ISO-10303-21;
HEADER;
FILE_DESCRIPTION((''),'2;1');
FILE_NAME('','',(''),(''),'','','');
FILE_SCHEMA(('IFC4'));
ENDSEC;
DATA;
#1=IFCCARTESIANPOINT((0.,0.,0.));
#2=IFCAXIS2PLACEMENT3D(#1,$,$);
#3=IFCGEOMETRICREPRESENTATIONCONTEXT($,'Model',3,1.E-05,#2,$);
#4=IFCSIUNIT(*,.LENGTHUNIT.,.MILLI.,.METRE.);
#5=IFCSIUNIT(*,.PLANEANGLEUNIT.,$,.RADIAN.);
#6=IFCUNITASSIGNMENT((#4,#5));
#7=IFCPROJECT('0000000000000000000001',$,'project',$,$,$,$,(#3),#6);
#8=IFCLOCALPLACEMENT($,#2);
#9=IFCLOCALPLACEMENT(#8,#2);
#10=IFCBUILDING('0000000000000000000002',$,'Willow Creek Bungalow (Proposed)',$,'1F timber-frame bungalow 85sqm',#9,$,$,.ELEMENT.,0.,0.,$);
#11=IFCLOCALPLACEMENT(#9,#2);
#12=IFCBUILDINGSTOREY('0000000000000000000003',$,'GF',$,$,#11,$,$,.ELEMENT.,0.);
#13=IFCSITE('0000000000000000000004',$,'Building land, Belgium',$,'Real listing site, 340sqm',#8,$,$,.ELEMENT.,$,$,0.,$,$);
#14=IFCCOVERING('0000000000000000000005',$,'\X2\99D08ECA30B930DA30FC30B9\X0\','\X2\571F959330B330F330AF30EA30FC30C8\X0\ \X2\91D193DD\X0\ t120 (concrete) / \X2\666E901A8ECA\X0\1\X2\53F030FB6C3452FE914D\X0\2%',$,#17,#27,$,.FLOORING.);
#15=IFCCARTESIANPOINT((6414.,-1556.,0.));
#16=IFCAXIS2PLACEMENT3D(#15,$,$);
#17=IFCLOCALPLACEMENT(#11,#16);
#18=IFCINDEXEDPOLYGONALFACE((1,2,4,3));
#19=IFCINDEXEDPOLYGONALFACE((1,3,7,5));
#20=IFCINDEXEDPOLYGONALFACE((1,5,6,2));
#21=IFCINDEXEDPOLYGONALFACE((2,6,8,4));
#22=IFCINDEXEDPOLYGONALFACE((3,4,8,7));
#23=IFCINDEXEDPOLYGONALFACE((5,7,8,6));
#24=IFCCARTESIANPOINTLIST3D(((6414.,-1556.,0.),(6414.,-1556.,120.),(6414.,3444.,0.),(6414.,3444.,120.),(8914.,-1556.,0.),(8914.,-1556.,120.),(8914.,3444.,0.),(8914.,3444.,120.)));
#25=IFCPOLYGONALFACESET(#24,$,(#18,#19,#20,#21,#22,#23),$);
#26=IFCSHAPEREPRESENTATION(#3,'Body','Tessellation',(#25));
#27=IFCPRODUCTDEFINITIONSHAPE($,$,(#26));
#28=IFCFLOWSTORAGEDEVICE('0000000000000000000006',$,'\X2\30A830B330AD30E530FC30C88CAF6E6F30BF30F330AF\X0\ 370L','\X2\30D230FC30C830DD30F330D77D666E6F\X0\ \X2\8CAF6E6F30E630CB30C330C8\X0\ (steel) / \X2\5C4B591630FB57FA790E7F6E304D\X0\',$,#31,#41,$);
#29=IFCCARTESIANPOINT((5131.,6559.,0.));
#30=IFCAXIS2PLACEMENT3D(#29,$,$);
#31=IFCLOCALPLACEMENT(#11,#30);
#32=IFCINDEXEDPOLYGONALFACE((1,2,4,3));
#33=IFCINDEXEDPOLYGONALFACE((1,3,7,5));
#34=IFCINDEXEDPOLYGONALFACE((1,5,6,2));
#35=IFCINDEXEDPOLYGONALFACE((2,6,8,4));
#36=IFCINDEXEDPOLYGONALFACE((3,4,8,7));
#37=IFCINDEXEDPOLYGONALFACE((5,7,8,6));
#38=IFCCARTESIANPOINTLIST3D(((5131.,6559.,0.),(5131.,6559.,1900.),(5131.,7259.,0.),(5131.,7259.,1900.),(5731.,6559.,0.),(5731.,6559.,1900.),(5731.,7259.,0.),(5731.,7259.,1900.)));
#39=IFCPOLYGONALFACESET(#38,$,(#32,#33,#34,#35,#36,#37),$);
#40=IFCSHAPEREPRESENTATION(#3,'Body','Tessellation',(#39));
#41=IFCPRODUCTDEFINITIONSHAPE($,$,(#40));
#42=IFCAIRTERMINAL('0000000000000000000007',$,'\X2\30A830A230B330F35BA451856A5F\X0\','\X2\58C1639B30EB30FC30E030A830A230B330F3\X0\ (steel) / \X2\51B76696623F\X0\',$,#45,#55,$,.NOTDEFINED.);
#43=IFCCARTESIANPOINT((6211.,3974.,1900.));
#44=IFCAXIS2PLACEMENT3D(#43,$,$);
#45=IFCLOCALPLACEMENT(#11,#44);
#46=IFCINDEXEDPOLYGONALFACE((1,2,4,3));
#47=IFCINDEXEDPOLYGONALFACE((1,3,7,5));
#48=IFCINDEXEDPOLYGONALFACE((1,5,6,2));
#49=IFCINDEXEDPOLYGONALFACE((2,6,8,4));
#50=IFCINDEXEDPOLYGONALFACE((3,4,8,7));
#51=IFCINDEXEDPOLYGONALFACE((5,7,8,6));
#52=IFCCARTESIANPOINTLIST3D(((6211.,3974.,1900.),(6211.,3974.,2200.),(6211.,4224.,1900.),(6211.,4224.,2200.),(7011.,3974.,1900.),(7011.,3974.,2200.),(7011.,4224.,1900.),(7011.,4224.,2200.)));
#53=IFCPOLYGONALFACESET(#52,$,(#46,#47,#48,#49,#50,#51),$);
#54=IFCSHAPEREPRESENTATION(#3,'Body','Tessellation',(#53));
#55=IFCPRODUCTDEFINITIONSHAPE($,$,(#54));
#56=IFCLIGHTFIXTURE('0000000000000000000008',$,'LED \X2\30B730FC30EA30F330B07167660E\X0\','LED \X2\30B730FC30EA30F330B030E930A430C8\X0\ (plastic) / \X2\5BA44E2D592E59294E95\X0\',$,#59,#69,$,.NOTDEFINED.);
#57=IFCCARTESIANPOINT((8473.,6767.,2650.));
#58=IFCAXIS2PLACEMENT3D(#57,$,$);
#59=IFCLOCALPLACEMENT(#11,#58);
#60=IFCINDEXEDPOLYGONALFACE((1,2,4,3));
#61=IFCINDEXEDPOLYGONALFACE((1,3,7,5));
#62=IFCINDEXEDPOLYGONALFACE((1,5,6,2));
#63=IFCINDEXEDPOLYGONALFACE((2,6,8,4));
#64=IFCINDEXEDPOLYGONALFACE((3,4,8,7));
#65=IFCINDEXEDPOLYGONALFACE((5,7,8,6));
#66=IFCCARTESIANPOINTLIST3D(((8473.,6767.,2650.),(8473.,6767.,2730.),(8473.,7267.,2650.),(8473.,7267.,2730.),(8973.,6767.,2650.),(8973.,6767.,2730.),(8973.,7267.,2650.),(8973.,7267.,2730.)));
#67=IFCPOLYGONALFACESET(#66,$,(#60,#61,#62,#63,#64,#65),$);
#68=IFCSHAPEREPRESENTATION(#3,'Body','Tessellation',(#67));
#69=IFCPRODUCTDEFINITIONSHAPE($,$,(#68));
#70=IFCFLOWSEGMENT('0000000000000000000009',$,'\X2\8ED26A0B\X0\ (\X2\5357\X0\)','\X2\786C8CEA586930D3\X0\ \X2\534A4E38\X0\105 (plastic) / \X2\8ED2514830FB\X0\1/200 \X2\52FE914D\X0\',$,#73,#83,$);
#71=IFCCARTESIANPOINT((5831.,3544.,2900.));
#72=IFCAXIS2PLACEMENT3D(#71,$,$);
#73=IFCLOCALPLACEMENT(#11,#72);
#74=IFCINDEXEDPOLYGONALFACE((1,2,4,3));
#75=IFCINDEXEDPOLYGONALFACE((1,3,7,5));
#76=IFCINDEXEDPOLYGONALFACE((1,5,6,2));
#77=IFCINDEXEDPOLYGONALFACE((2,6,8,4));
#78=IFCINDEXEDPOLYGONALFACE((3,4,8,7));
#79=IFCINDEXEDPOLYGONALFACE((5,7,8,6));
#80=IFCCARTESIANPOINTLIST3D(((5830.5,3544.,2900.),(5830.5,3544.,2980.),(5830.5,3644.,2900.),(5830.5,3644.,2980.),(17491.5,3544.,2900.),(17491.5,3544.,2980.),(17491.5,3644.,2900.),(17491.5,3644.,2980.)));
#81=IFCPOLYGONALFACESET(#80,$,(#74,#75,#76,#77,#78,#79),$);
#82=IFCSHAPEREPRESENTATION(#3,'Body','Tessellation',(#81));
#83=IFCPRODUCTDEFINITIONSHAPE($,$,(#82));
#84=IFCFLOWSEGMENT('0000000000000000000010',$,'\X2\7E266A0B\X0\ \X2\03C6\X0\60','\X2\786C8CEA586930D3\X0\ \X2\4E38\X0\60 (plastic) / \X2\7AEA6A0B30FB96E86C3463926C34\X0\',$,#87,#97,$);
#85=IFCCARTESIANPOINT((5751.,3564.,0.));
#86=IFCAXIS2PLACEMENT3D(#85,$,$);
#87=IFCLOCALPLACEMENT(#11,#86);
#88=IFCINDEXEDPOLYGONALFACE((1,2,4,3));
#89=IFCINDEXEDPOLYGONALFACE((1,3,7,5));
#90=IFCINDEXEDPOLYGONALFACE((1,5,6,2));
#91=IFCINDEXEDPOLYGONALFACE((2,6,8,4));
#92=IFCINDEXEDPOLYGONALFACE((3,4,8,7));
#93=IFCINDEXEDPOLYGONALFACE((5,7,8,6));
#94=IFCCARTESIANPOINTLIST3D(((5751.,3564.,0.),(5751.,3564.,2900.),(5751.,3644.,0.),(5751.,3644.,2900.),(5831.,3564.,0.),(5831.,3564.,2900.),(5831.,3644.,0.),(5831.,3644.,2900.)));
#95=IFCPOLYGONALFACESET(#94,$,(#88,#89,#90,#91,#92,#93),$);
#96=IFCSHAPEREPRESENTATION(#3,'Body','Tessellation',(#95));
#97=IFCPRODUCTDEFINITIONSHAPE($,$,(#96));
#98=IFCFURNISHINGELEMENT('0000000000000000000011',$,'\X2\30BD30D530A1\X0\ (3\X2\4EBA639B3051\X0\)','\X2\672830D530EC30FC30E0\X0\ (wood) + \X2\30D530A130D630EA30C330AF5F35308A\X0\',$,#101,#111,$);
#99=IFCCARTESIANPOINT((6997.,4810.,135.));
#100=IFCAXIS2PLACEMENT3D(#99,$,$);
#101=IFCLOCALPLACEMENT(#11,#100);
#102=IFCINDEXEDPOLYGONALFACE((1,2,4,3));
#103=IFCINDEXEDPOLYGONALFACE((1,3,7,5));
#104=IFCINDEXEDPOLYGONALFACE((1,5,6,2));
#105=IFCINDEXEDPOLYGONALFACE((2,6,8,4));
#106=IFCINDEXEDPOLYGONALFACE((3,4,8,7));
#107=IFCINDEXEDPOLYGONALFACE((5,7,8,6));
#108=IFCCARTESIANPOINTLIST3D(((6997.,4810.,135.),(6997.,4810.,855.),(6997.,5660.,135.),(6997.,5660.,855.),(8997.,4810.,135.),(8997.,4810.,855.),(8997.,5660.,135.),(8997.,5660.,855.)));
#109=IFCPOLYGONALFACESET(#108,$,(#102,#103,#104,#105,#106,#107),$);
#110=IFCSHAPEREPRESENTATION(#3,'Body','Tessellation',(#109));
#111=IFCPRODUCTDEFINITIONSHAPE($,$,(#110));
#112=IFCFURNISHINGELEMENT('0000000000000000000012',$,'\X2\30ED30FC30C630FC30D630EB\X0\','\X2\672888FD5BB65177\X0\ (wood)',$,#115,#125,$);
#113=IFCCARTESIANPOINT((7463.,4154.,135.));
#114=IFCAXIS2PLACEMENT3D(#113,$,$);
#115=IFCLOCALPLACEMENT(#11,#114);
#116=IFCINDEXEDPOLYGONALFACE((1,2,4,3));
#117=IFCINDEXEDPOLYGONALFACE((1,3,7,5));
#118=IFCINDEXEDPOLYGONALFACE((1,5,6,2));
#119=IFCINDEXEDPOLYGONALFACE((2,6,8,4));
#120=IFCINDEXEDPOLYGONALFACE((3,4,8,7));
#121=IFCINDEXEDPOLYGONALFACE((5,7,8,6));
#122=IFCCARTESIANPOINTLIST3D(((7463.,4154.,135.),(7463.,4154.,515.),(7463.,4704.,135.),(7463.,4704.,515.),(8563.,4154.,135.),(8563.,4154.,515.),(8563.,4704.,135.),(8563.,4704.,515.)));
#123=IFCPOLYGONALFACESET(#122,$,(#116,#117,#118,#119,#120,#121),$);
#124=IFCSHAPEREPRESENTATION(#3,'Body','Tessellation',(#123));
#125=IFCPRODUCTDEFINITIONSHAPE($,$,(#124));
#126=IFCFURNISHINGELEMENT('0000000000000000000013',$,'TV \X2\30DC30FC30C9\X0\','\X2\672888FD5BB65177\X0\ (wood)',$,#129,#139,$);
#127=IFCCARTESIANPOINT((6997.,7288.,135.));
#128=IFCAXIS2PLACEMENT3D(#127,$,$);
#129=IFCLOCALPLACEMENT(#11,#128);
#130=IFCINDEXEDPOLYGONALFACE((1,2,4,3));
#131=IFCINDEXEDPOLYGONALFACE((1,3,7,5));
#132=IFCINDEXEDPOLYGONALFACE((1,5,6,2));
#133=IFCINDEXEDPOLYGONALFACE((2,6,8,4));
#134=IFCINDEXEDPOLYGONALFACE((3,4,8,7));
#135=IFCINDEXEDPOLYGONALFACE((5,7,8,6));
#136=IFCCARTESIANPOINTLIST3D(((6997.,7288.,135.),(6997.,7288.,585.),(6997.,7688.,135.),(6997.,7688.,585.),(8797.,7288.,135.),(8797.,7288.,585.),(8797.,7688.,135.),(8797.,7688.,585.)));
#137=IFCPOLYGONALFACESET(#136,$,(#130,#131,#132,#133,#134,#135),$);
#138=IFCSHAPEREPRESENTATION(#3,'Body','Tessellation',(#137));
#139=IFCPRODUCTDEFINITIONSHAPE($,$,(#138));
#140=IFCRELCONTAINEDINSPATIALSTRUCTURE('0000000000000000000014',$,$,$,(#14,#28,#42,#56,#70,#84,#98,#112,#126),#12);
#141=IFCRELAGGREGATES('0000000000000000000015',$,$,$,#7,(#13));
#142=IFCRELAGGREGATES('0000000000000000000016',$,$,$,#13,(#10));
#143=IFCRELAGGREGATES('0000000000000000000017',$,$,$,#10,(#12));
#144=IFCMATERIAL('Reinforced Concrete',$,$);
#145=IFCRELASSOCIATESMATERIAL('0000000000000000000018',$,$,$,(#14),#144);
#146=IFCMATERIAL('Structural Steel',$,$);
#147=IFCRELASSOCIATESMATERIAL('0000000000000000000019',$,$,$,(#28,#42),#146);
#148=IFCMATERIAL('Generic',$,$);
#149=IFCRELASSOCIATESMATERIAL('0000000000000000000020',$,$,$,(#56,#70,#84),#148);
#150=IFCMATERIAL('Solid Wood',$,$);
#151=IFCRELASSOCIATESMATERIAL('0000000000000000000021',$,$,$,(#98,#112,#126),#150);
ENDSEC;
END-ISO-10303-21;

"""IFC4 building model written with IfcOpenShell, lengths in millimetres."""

from ifc_helpers import new_model, si_unit, frame, frame_2d, origin, place, context, project, spatial, rectangle, extrude, material, element, save


model = new_model("IFC4")

# Units and contexts
model_context = context("Model", 3, precision=1e-05, world=origin())
ifc_project = project(units=[si_unit("LENGTHUNIT", "METRE", prefix="MILLI"), si_unit("PLANEANGLEUNIT", "RADIAN")], contexts=[model_context])

# Site, building, storey
site_placement = place(None, origin())
site = spatial("IfcSite", under=ifc_project, at=site_placement, Name="Building land, Belgium", ObjectType="Real listing site, 340sqm", CompositionType="ELEMENT", RefElevation=0.0)
building_placement = place(site_placement, origin())
building = spatial("IfcBuilding", under=site, at=building_placement, Name="Willow Creek Bungalow (Proposed)", ObjectType="1F timber-frame bungalow 85sqm", CompositionType="ELEMENT", ElevationOfRefHeight=0.0, ElevationOfTerrain=0.0)
storey_placement = place(building_placement, origin())
storey = spatial("IfcBuildingStorey", under=building, at=storey_placement, Name="GF", CompositionType="ELEMENT", Elevation=0.0)

# Shared definitions
ifc_material_1 = material(Name="Solid Wood")

# Shared definitions
ifc_material_2 = material(Name="Reinforced Concrete")

# Shared definitions
ifc_material_3 = material(Name="Structural Steel")

# Covering
ifc_material_4 = material(Name="Generic")
covering_1_placement = place(storey_placement, frame((6414.0, -1556.0, 0.0)))
element("IfcCovering", 1, at=covering_1_placement, inside=storey, material=ifc_material_2, Name="駐車スペース", Description="土間コンクリート 金鏝 t120 (concrete) / 普通車1台・水勾配2%", PredefinedType="FLOORING", context=model_context, shape_type="SweptSolid", body=[
    extrude(rectangle(XDim=2500.0, YDim=5000.0, at=frame_2d((1250.0, 2500.0))), frame((6414.0, -1556.0, 0.0)), (0.0, 0.0, 1.0), 120.0),
])

# Flow storage device
flow_storage_device_placement = place(storey_placement, frame((5131.0, 6559.0, 0.0)))
element("IfcFlowStorageDevice", 2, at=flow_storage_device_placement, inside=storey, material=ifc_material_3, Name="エコキュート貯湯タンク 370L", Description="ヒートポンプ給湯 貯湯ユニット (steel) / 屋外・基礎置き", context=model_context, shape_type="SweptSolid", body=[
    extrude(rectangle(XDim=600.0, YDim=700.0, at=frame_2d((300.0, 350.0))), frame((5131.0, 6559.0, 0.0)), (0.0, 0.0, 1.0), 1900.0),
])

# Air terminal
air_terminal_placement = place(storey_placement, frame((6211.0, 3974.0, 1900.0)))
element("IfcAirTerminal", 3, at=air_terminal_placement, inside=storey, material=ifc_material_3, Name="エアコン室内機", Description="壁掛ルームエアコン (steel) / 冷暖房", PredefinedType="NOTDEFINED", context=model_context, shape_type="SweptSolid", body=[
    extrude(rectangle(XDim=800.0, YDim=250.0, at=frame_2d((400.0, 125.0))), frame((6211.0, 3974.0, 1900.0)), (0.0, 0.0, 1.0), 300.0),
])

# Light fixture
light_fixture_placement = place(storey_placement, frame((8473.0, 6767.0, 2650.0)))
element("IfcLightFixture", 4, at=light_fixture_placement, inside=storey, material=ifc_material_4, Name="LED シーリング照明", Description="LED シーリングライト (plastic) / 室中央天井", PredefinedType="NOTDEFINED", context=model_context, shape_type="SweptSolid", body=[
    extrude(rectangle(XDim=500.0, YDim=500.0, at=frame_2d((250.0, 250.0))), frame((8473.0, 6767.0, 2650.0)), (0.0, 0.0, 1.0), 80.0),
])

# Flow segments
flow_segment_1_placement = place(storey_placement, frame((5831.0, 3544.0, 2900.0)))
element("IfcFlowSegment", 5, at=flow_segment_1_placement, inside=storey, material=ifc_material_4, Name="軒樋 (南)", Description="硬質塩ビ 半丸105 (plastic) / 軒先・1/200 勾配", context=model_context, shape_type="SweptSolid", body=[
    extrude(rectangle(XDim=11661.0, YDim=100.0, at=frame_2d((5830.0, 50.0))), frame((5831.0, 3544.0, 2900.0)), (0.0, 0.0, 1.0), 80.0),
])
flow_segment_2_placement = place(storey_placement, frame((5751.0, 3564.0, 0.0)))
element("IfcFlowSegment", 6, at=flow_segment_2_placement, inside=storey, material=ifc_material_4, Name="縦樋 φ60", Description="硬質塩ビ 丸60 (plastic) / 竪樋・雨水排水", context=model_context, shape_type="SweptSolid", body=[
    extrude(rectangle(XDim=80.0, YDim=80.0, at=frame_2d((40.0, 40.0))), frame((5751.0, 3564.0, 0.0)), (0.0, 0.0, 1.0), 2900.0),
])

# Furnishing elements
furnishing_1_placement = place(storey_placement, frame((6997.0, 4810.0, 135.0)))
element("IfcFurnishingElement", 7, at=furnishing_1_placement, inside=storey, material=ifc_material_1, Name="ソファ (3人掛け)", Description="木フレーム (wood) + ファブリック張り", context=model_context, shape_type="SweptSolid", body=[
    extrude(rectangle(XDim=2000.0, YDim=850.0, at=frame_2d((1000.0, 425.0))), frame((6997.0, 4810.0, 135.0)), (0.0, 0.0, 1.0), 720.0),
])
furnishing_2_placement = place(storey_placement, frame((7463.0, 4154.0, 135.0)))
element("IfcFurnishingElement", 8, at=furnishing_2_placement, inside=storey, material=ifc_material_1, Name="ローテーブル", Description="木製家具 (wood)", context=model_context, shape_type="SweptSolid", body=[
    extrude(rectangle(XDim=1100.0, YDim=550.0, at=frame_2d((550.0, 275.0))), frame((7463.0, 4154.0, 135.0)), (0.0, 0.0, 1.0), 380.0),
])
furnishing_3_placement = place(storey_placement, frame((6997.0, 7288.0, 135.0)))
element("IfcFurnishingElement", 9, at=furnishing_3_placement, inside=storey, material=ifc_material_1, Name="TV ボード", Description="木製家具 (wood)", context=model_context, shape_type="SweptSolid", body=[
    extrude(rectangle(XDim=1800.0, YDim=400.0, at=frame_2d((900.0, 200.0))), frame((6997.0, 7288.0, 135.0)), (0.0, 0.0, 1.0), 450.0),
])

save(model, "model.ifc")
